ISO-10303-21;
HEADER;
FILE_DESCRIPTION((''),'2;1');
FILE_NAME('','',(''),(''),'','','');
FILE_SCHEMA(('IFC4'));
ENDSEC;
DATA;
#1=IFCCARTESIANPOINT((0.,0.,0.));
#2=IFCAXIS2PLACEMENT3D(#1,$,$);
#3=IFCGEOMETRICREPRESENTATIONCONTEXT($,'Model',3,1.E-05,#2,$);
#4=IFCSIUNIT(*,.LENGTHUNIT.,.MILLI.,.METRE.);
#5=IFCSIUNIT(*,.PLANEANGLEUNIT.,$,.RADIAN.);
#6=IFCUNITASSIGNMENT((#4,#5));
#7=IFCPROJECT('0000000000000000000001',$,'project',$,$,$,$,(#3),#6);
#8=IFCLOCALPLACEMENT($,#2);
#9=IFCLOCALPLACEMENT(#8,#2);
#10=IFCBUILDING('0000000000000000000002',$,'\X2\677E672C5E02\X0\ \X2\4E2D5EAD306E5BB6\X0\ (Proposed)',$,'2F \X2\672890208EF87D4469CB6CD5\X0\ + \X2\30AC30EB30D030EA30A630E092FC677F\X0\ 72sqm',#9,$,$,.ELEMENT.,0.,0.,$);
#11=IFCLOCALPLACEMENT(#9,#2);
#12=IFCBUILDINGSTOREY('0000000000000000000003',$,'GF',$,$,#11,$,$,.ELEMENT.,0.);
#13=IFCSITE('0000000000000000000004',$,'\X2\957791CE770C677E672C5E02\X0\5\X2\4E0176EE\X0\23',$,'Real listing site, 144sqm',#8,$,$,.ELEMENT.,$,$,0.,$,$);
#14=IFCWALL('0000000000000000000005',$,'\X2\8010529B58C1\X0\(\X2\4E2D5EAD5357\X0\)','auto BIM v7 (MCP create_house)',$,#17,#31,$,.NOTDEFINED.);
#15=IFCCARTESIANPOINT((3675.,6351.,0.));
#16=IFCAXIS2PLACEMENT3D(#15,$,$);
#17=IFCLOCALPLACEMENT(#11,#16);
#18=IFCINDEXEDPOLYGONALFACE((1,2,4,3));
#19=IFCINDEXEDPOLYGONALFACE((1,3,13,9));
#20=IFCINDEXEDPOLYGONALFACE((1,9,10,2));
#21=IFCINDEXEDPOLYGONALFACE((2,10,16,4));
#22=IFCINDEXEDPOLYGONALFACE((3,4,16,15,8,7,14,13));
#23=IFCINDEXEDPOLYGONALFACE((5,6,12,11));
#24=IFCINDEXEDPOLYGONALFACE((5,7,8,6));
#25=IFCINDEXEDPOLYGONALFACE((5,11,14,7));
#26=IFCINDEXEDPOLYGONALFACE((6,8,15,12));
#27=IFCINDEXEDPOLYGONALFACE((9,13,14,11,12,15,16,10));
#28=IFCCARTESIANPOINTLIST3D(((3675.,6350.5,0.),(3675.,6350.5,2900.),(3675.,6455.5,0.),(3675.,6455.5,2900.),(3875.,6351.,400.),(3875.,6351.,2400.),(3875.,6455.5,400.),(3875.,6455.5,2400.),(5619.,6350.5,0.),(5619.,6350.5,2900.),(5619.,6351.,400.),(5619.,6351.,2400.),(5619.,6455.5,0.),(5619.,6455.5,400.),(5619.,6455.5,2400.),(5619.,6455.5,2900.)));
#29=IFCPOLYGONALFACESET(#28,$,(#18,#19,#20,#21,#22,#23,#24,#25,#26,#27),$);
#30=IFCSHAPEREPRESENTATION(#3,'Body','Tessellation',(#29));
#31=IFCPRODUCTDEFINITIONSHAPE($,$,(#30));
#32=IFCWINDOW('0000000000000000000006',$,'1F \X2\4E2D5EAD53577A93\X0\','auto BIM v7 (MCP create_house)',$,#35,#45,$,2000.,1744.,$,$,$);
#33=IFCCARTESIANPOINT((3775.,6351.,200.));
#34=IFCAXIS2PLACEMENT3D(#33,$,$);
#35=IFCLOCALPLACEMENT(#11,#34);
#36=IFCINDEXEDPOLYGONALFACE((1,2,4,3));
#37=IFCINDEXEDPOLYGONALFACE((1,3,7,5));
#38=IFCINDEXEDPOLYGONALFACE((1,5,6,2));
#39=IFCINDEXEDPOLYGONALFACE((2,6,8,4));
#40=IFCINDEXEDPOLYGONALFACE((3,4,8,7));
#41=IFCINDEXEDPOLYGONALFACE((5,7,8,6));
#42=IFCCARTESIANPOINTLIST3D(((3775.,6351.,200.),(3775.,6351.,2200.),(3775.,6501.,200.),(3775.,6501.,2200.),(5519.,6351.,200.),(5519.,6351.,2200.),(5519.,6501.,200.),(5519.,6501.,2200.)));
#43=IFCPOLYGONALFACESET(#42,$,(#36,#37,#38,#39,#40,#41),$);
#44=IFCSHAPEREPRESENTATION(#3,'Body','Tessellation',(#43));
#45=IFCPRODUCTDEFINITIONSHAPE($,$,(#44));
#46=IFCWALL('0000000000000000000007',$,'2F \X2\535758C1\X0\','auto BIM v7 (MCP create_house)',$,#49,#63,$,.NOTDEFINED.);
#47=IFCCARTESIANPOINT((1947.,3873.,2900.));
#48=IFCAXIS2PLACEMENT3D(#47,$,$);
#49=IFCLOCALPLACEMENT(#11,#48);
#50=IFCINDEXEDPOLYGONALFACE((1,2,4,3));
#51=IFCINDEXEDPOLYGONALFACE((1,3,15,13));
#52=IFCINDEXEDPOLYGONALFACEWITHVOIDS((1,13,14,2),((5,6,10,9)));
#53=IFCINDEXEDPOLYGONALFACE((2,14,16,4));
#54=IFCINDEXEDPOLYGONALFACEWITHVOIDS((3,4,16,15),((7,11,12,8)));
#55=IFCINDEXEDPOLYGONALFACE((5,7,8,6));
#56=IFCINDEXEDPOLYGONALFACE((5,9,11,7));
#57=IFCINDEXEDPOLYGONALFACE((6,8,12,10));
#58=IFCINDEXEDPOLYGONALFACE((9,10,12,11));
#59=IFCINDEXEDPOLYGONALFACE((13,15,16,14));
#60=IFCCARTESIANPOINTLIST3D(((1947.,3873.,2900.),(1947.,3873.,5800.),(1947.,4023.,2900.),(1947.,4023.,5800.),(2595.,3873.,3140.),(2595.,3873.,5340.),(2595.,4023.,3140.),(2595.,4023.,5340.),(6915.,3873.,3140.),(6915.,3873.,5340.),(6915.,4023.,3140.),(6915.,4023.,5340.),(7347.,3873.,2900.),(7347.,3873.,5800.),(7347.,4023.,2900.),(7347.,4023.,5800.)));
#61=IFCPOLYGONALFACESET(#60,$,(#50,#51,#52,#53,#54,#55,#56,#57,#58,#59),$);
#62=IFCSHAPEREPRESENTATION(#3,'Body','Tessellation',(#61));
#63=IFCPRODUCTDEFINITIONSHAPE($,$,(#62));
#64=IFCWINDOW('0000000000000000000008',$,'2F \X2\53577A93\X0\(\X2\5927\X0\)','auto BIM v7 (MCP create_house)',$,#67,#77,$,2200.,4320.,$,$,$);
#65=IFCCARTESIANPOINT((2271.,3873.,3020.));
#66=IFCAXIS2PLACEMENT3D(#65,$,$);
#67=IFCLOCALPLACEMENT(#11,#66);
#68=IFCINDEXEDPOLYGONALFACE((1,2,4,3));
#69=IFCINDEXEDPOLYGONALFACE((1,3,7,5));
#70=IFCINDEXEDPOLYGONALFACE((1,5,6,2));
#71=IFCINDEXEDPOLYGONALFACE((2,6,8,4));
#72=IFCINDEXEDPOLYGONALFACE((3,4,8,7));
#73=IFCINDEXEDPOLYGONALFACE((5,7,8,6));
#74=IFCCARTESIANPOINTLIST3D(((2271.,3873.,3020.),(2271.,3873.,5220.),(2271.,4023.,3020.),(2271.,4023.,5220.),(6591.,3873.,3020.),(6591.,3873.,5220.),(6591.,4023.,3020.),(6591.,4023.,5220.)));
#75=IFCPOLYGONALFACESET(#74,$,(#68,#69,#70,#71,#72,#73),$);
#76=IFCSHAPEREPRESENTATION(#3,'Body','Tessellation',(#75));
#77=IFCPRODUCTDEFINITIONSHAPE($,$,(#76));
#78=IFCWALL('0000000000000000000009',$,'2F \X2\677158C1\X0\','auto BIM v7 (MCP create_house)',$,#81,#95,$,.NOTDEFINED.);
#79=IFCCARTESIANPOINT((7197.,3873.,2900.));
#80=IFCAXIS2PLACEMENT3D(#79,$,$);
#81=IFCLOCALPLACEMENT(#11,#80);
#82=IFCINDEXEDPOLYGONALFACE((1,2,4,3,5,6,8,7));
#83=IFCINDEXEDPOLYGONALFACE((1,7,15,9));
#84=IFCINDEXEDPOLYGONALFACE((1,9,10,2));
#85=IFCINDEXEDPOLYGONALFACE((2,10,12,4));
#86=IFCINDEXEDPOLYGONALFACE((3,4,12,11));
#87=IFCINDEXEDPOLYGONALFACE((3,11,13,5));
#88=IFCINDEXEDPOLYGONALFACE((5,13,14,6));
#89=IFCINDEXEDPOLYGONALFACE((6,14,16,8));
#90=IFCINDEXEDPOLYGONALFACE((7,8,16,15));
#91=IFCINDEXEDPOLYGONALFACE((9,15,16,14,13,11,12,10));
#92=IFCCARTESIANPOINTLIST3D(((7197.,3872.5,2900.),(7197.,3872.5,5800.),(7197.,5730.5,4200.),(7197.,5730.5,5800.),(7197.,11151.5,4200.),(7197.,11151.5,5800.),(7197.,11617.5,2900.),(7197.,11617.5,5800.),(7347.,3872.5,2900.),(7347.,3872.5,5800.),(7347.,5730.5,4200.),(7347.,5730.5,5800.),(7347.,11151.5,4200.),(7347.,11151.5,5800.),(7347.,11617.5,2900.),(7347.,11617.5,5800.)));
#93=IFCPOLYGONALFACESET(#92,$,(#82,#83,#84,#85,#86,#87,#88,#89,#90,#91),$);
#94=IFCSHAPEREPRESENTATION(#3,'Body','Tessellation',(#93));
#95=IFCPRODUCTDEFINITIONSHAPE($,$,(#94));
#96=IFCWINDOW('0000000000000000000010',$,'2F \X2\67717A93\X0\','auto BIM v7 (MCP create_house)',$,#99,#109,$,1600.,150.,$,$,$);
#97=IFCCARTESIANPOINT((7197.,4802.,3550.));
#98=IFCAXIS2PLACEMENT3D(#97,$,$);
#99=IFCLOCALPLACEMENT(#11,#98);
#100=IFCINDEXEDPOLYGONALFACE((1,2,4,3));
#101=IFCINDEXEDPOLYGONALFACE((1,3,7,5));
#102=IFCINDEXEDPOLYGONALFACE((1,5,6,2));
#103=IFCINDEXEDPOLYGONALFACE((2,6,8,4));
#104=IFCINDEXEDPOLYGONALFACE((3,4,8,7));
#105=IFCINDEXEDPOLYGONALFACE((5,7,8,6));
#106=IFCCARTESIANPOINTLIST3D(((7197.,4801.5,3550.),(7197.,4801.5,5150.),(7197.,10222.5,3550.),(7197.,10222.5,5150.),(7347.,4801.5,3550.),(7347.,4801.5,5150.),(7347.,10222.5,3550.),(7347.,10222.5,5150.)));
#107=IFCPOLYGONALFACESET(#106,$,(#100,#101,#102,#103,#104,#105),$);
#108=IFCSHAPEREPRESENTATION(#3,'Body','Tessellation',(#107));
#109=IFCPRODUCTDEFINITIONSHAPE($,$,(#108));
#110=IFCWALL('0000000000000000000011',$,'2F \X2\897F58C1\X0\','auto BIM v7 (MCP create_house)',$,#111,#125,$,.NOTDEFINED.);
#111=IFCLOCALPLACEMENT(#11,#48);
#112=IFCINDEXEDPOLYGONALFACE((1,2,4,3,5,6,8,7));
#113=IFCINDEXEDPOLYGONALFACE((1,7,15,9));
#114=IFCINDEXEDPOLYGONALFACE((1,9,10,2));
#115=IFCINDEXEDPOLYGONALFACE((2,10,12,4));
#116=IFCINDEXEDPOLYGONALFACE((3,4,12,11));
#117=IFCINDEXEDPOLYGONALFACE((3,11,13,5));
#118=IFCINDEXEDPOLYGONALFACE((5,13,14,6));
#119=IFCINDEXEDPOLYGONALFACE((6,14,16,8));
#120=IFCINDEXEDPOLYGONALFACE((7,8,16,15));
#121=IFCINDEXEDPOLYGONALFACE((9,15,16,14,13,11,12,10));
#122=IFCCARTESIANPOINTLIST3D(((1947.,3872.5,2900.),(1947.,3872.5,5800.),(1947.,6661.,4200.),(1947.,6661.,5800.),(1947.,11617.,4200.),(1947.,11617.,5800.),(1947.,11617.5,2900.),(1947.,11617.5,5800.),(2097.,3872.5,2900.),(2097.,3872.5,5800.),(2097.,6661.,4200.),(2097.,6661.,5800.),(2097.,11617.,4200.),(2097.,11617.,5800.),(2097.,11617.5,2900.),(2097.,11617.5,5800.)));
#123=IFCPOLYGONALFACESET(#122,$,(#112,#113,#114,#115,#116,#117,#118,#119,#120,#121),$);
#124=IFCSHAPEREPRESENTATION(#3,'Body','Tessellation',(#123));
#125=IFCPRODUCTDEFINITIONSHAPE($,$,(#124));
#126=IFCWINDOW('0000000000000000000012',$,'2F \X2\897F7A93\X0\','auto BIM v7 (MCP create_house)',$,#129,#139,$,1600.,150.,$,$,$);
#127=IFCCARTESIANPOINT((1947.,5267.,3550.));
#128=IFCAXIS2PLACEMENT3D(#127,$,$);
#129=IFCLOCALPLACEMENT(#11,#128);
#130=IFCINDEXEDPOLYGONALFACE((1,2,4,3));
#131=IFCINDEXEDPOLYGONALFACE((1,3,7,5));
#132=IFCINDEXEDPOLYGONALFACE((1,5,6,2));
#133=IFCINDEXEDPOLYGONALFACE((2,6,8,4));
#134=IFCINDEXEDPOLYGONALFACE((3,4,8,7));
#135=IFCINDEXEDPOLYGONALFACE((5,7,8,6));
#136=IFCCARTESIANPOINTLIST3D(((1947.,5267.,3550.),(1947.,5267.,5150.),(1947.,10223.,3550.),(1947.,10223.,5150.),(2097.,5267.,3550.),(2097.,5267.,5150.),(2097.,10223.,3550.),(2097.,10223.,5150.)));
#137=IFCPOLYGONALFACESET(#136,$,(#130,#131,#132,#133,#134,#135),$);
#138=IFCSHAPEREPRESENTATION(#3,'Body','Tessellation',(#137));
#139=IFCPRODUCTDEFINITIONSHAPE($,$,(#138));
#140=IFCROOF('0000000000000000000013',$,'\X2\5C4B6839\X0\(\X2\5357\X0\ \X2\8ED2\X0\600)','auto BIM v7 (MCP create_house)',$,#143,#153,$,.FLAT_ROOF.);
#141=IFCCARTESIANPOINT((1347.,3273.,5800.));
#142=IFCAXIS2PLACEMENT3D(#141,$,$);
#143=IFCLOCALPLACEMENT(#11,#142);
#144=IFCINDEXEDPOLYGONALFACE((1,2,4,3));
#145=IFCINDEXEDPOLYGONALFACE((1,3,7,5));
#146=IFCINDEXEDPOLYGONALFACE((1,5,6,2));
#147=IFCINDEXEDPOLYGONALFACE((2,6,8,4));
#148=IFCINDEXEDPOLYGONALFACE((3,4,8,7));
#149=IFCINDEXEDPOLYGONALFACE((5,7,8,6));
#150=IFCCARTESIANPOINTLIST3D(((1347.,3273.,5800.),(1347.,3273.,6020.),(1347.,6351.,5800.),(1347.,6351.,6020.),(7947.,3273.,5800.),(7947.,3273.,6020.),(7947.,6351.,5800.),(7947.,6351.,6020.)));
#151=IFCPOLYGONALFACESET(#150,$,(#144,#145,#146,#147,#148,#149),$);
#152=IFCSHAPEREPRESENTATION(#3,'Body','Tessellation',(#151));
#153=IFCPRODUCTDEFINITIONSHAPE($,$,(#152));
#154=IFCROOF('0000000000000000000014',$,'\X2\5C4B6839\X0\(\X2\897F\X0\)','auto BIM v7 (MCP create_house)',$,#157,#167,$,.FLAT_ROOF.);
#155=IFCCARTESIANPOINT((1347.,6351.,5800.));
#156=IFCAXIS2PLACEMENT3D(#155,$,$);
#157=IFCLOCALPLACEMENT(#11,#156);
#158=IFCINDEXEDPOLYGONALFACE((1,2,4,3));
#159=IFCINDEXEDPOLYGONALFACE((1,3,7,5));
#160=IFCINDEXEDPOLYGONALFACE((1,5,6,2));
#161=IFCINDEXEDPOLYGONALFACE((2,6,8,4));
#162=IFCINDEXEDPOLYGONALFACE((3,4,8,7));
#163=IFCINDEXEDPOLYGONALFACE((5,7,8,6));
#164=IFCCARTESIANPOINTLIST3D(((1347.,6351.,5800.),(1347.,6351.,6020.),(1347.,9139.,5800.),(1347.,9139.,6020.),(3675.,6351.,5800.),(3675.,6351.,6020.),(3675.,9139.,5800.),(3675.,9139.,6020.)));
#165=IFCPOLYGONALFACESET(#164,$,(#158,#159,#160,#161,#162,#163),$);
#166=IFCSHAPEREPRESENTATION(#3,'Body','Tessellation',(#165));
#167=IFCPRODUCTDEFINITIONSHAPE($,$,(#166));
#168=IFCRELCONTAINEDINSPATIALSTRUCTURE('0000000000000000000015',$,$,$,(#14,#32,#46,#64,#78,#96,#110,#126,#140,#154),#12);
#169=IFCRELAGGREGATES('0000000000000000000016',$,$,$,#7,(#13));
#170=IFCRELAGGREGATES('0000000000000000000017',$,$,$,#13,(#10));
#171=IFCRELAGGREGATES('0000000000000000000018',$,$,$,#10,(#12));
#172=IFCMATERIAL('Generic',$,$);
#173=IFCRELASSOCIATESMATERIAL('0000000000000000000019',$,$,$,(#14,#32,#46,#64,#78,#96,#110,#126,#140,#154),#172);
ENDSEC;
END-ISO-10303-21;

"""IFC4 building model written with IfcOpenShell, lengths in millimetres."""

from ifc_helpers import new_model, si_unit, frame, frame_2d, origin, place, context, project, spatial, rectangle, extrude, material, element, fill, save


model = new_model("IFC4")

# Units and contexts
model_context = context("Model", 3, precision=1e-05, world=origin())
ifc_project = project(units=[si_unit("LENGTHUNIT", "METRE", prefix="MILLI"), si_unit("PLANEANGLEUNIT", "RADIAN")], contexts=[model_context])

# Site, building, storey
site_placement = place(None, origin())
site = spatial("IfcSite", under=ifc_project, at=site_placement, Name="長野県松本市5丁目23", ObjectType="Real listing site, 144sqm", CompositionType="ELEMENT", RefElevation=0.0)
building_placement = place(site_placement, origin())
building = spatial("IfcBuilding", under=site, at=building_placement, Name="松本市 中庭の家 (Proposed)", ObjectType="2F 木造軸組構法 + ガルバリウム鋼板 72sqm", CompositionType="ELEMENT", ElevationOfRefHeight=0.0, ElevationOfTerrain=0.0)
storey_placement = place(building_placement, origin())
storey = spatial("IfcBuildingStorey", under=building, at=storey_placement, Name="GF", CompositionType="ELEMENT", Elevation=0.0)

# Shared definitions
ifc_material = material(Name="Generic")

# Wall, opening, window
wall_1_placement = place(storey_placement, frame((3675.0, 6351.0, 0.0)))
wall_1 = element("IfcWall", 1, at=wall_1_placement, inside=storey, material=ifc_material, Name="耐力壁(中庭南)", Description="auto BIM v7 (MCP create_house)", PredefinedType="NOTDEFINED", context=model_context, shape_type="SweptSolid", body=[
    extrude(rectangle(XDim=1944.0, YDim=105.0, at=frame_2d((972.0, 52.0))), frame((3675.0, 6351.0, 0.0)), (0.0, 0.0, 1.0), 2900.0),
])
opening_1_placement = place(storey_placement, frame((3775.0, 6351.0, 200.0)))
opening_1 = element("IfcOpeningElement", 2, at=opening_1_placement, cuts=wall_1, PredefinedType="NOTDEFINED", context=model_context, shape_type="SweptSolid", body=[
    extrude(rectangle(XDim=1744.0, YDim=150.0, at=frame_2d((872.0, 75.0))), frame((3775.0, 6351.0, 200.0)), (0.0, 0.0, 1.0), 2000.0),
])
window_1_placement = place(storey_placement, frame((3775.0, 6351.0, 200.0)))
window_1 = element("IfcWindow", 3, at=window_1_placement, inside=storey, material=ifc_material, Name="1F 中庭南窓", Description="auto BIM v7 (MCP create_house)", OverallHeight=2000.0, OverallWidth=1744.0, context=model_context, shape_type="SweptSolid", body=[
    extrude(rectangle(XDim=1744.0, YDim=150.0, at=frame_2d((872.0, 75.0))), frame((3775.0, 6351.0, 200.0)), (0.0, 0.0, 1.0), 2000.0),
])
fill(opening_1, window_1)

# Walls, openings, windows
wall_2_placement = place(storey_placement, frame((1947.0, 3873.0, 2900.0)))
wall_2 = element("IfcWall", 4, at=wall_2_placement, inside=storey, material=ifc_material, Name="2F 南壁", Description="auto BIM v7 (MCP create_house)", PredefinedType="NOTDEFINED", context=model_context, shape_type="SweptSolid", body=[
    extrude(rectangle(XDim=5400.0, YDim=150.0, at=frame_2d((2700.0, 75.0))), frame((1947.0, 3873.0, 2900.0)), (0.0, 0.0, 1.0), 2900.0),
])
opening_2_placement = place(storey_placement, frame((2271.0, 3873.0, 3020.0)))
opening_2 = element("IfcOpeningElement", 5, at=opening_2_placement, cuts=wall_2, PredefinedType="NOTDEFINED", context=model_context, shape_type="SweptSolid", body=[
    extrude(rectangle(XDim=4320.0, YDim=150.0, at=frame_2d((2160.0, 75.0))), frame((2271.0, 3873.0, 3020.0)), (0.0, 0.0, 1.0), 2200.0),
])
window_2_placement = place(storey_placement, frame((2271.0, 3873.0, 3020.0)))
window_2 = element("IfcWindow", 6, at=window_2_placement, inside=storey, material=ifc_material, Name="2F 南窓(大)", Description="auto BIM v7 (MCP create_house)", OverallHeight=2200.0, OverallWidth=4320.0, context=model_context, shape_type="SweptSolid", body=[
    extrude(rectangle(XDim=4320.0, YDim=150.0, at=frame_2d((2160.0, 75.0))), frame((2271.0, 3873.0, 3020.0)), (0.0, 0.0, 1.0), 2200.0),
])
fill(opening_2, window_2)
wall_3_placement = place(storey_placement, frame((7197.0, 3873.0, 2900.0)))
wall_3 = element("IfcWall", 7, at=wall_3_placement, inside=storey, material=ifc_material, Name="2F 東壁", Description="auto BIM v7 (MCP create_house)", PredefinedType="NOTDEFINED", context=model_context, shape_type="SweptSolid", body=[
    extrude(rectangle(XDim=150.0, YDim=7745.0, at=frame_2d((75.0, 3872.0))), frame((7197.0, 3873.0, 2900.0)), (0.0, 0.0, 1.0), 2900.0),
])
opening_3_placement = place(storey_placement, frame((7197.0, 4802.0, 3550.0)))
opening_3 = element("IfcOpeningElement", 8, at=opening_3_placement, cuts=wall_3, PredefinedType="NOTDEFINED", context=model_context, shape_type="SweptSolid", body=[
    extrude(rectangle(XDim=150.0, YDim=5421.0, at=frame_2d((75.0, 2710.0))), frame((7197.0, 4802.0, 3550.0)), (0.0, 0.0, 1.0), 1600.0),
])
window_3_placement = place(storey_placement, frame((7197.0, 4802.0, 3550.0)))
window_3 = element("IfcWindow", 9, at=window_3_placement, inside=storey, material=ifc_material, Name="2F 東窓", Description="auto BIM v7 (MCP create_house)", OverallHeight=1600.0, OverallWidth=150.0, context=model_context, shape_type="SweptSolid", body=[
    extrude(rectangle(XDim=150.0, YDim=5421.0, at=frame_2d((75.0, 2710.0))), frame((7197.0, 4802.0, 3550.0)), (0.0, 0.0, 1.0), 1600.0),
])
fill(opening_3, window_3)
wall_4_placement = place(storey_placement, frame((1947.0, 3873.0, 2900.0)))
wall_4 = element("IfcWall", 10, at=wall_4_placement, inside=storey, material=ifc_material, Name="2F 西壁", Description="auto BIM v7 (MCP create_house)", PredefinedType="NOTDEFINED", context=model_context, shape_type="SweptSolid", body=[
    extrude(rectangle(XDim=150.0, YDim=7745.0, at=frame_2d((75.0, 3872.0))), frame((1947.0, 3873.0, 2900.0)), (0.0, 0.0, 1.0), 2900.0),
])
opening_4_placement = place(storey_placement, frame((1947.0, 5267.0, 3550.0)))
opening_4 = element("IfcOpeningElement", 11, at=opening_4_placement, cuts=wall_4, PredefinedType="NOTDEFINED", context=model_context, shape_type="SweptSolid", body=[
    extrude(rectangle(XDim=150.0, YDim=4956.0, at=frame_2d((75.0, 2478.0))), frame((1947.0, 5267.0, 3550.0)), (0.0, 0.0, 1.0), 1600.0),
])
window_4_placement = place(storey_placement, frame((1947.0, 5267.0, 3550.0)))
window_4 = element("IfcWindow", 12, at=window_4_placement, inside=storey, material=ifc_material, Name="2F 西窓", Description="auto BIM v7 (MCP create_house)", OverallHeight=1600.0, OverallWidth=150.0, context=model_context, shape_type="SweptSolid", body=[
    extrude(rectangle(XDim=150.0, YDim=4956.0, at=frame_2d((75.0, 2478.0))), frame((1947.0, 5267.0, 3550.0)), (0.0, 0.0, 1.0), 1600.0),
])
fill(opening_4, window_4)

# Roofs
roof_1_placement = place(storey_placement, frame((1347.0, 3273.0, 5800.0)))
element("IfcRoof", 13, at=roof_1_placement, inside=storey, material=ifc_material, Name="屋根(南 軒600)", Description="auto BIM v7 (MCP create_house)", PredefinedType="FLAT_ROOF", context=model_context, shape_type="SweptSolid", body=[
    extrude(rectangle(XDim=6600.0, YDim=3078.0, at=frame_2d((3300.0, 1539.0))), frame((1347.0, 3273.0, 5800.0)), (0.0, 0.0, 1.0), 220.0),
])
roof_2_placement = place(storey_placement, frame((1347.0, 6351.0, 5800.0)))
element("IfcRoof", 14, at=roof_2_placement, inside=storey, material=ifc_material, Name="屋根(西)", Description="auto BIM v7 (MCP create_house)", PredefinedType="FLAT_ROOF", context=model_context, shape_type="SweptSolid", body=[
    extrude(rectangle(XDim=2328.0, YDim=2788.0, at=frame_2d((1164.0, 1394.0))), frame((1347.0, 6351.0, 5800.0)), (0.0, 0.0, 1.0), 220.0),
])

save(model, "model.ifc")
